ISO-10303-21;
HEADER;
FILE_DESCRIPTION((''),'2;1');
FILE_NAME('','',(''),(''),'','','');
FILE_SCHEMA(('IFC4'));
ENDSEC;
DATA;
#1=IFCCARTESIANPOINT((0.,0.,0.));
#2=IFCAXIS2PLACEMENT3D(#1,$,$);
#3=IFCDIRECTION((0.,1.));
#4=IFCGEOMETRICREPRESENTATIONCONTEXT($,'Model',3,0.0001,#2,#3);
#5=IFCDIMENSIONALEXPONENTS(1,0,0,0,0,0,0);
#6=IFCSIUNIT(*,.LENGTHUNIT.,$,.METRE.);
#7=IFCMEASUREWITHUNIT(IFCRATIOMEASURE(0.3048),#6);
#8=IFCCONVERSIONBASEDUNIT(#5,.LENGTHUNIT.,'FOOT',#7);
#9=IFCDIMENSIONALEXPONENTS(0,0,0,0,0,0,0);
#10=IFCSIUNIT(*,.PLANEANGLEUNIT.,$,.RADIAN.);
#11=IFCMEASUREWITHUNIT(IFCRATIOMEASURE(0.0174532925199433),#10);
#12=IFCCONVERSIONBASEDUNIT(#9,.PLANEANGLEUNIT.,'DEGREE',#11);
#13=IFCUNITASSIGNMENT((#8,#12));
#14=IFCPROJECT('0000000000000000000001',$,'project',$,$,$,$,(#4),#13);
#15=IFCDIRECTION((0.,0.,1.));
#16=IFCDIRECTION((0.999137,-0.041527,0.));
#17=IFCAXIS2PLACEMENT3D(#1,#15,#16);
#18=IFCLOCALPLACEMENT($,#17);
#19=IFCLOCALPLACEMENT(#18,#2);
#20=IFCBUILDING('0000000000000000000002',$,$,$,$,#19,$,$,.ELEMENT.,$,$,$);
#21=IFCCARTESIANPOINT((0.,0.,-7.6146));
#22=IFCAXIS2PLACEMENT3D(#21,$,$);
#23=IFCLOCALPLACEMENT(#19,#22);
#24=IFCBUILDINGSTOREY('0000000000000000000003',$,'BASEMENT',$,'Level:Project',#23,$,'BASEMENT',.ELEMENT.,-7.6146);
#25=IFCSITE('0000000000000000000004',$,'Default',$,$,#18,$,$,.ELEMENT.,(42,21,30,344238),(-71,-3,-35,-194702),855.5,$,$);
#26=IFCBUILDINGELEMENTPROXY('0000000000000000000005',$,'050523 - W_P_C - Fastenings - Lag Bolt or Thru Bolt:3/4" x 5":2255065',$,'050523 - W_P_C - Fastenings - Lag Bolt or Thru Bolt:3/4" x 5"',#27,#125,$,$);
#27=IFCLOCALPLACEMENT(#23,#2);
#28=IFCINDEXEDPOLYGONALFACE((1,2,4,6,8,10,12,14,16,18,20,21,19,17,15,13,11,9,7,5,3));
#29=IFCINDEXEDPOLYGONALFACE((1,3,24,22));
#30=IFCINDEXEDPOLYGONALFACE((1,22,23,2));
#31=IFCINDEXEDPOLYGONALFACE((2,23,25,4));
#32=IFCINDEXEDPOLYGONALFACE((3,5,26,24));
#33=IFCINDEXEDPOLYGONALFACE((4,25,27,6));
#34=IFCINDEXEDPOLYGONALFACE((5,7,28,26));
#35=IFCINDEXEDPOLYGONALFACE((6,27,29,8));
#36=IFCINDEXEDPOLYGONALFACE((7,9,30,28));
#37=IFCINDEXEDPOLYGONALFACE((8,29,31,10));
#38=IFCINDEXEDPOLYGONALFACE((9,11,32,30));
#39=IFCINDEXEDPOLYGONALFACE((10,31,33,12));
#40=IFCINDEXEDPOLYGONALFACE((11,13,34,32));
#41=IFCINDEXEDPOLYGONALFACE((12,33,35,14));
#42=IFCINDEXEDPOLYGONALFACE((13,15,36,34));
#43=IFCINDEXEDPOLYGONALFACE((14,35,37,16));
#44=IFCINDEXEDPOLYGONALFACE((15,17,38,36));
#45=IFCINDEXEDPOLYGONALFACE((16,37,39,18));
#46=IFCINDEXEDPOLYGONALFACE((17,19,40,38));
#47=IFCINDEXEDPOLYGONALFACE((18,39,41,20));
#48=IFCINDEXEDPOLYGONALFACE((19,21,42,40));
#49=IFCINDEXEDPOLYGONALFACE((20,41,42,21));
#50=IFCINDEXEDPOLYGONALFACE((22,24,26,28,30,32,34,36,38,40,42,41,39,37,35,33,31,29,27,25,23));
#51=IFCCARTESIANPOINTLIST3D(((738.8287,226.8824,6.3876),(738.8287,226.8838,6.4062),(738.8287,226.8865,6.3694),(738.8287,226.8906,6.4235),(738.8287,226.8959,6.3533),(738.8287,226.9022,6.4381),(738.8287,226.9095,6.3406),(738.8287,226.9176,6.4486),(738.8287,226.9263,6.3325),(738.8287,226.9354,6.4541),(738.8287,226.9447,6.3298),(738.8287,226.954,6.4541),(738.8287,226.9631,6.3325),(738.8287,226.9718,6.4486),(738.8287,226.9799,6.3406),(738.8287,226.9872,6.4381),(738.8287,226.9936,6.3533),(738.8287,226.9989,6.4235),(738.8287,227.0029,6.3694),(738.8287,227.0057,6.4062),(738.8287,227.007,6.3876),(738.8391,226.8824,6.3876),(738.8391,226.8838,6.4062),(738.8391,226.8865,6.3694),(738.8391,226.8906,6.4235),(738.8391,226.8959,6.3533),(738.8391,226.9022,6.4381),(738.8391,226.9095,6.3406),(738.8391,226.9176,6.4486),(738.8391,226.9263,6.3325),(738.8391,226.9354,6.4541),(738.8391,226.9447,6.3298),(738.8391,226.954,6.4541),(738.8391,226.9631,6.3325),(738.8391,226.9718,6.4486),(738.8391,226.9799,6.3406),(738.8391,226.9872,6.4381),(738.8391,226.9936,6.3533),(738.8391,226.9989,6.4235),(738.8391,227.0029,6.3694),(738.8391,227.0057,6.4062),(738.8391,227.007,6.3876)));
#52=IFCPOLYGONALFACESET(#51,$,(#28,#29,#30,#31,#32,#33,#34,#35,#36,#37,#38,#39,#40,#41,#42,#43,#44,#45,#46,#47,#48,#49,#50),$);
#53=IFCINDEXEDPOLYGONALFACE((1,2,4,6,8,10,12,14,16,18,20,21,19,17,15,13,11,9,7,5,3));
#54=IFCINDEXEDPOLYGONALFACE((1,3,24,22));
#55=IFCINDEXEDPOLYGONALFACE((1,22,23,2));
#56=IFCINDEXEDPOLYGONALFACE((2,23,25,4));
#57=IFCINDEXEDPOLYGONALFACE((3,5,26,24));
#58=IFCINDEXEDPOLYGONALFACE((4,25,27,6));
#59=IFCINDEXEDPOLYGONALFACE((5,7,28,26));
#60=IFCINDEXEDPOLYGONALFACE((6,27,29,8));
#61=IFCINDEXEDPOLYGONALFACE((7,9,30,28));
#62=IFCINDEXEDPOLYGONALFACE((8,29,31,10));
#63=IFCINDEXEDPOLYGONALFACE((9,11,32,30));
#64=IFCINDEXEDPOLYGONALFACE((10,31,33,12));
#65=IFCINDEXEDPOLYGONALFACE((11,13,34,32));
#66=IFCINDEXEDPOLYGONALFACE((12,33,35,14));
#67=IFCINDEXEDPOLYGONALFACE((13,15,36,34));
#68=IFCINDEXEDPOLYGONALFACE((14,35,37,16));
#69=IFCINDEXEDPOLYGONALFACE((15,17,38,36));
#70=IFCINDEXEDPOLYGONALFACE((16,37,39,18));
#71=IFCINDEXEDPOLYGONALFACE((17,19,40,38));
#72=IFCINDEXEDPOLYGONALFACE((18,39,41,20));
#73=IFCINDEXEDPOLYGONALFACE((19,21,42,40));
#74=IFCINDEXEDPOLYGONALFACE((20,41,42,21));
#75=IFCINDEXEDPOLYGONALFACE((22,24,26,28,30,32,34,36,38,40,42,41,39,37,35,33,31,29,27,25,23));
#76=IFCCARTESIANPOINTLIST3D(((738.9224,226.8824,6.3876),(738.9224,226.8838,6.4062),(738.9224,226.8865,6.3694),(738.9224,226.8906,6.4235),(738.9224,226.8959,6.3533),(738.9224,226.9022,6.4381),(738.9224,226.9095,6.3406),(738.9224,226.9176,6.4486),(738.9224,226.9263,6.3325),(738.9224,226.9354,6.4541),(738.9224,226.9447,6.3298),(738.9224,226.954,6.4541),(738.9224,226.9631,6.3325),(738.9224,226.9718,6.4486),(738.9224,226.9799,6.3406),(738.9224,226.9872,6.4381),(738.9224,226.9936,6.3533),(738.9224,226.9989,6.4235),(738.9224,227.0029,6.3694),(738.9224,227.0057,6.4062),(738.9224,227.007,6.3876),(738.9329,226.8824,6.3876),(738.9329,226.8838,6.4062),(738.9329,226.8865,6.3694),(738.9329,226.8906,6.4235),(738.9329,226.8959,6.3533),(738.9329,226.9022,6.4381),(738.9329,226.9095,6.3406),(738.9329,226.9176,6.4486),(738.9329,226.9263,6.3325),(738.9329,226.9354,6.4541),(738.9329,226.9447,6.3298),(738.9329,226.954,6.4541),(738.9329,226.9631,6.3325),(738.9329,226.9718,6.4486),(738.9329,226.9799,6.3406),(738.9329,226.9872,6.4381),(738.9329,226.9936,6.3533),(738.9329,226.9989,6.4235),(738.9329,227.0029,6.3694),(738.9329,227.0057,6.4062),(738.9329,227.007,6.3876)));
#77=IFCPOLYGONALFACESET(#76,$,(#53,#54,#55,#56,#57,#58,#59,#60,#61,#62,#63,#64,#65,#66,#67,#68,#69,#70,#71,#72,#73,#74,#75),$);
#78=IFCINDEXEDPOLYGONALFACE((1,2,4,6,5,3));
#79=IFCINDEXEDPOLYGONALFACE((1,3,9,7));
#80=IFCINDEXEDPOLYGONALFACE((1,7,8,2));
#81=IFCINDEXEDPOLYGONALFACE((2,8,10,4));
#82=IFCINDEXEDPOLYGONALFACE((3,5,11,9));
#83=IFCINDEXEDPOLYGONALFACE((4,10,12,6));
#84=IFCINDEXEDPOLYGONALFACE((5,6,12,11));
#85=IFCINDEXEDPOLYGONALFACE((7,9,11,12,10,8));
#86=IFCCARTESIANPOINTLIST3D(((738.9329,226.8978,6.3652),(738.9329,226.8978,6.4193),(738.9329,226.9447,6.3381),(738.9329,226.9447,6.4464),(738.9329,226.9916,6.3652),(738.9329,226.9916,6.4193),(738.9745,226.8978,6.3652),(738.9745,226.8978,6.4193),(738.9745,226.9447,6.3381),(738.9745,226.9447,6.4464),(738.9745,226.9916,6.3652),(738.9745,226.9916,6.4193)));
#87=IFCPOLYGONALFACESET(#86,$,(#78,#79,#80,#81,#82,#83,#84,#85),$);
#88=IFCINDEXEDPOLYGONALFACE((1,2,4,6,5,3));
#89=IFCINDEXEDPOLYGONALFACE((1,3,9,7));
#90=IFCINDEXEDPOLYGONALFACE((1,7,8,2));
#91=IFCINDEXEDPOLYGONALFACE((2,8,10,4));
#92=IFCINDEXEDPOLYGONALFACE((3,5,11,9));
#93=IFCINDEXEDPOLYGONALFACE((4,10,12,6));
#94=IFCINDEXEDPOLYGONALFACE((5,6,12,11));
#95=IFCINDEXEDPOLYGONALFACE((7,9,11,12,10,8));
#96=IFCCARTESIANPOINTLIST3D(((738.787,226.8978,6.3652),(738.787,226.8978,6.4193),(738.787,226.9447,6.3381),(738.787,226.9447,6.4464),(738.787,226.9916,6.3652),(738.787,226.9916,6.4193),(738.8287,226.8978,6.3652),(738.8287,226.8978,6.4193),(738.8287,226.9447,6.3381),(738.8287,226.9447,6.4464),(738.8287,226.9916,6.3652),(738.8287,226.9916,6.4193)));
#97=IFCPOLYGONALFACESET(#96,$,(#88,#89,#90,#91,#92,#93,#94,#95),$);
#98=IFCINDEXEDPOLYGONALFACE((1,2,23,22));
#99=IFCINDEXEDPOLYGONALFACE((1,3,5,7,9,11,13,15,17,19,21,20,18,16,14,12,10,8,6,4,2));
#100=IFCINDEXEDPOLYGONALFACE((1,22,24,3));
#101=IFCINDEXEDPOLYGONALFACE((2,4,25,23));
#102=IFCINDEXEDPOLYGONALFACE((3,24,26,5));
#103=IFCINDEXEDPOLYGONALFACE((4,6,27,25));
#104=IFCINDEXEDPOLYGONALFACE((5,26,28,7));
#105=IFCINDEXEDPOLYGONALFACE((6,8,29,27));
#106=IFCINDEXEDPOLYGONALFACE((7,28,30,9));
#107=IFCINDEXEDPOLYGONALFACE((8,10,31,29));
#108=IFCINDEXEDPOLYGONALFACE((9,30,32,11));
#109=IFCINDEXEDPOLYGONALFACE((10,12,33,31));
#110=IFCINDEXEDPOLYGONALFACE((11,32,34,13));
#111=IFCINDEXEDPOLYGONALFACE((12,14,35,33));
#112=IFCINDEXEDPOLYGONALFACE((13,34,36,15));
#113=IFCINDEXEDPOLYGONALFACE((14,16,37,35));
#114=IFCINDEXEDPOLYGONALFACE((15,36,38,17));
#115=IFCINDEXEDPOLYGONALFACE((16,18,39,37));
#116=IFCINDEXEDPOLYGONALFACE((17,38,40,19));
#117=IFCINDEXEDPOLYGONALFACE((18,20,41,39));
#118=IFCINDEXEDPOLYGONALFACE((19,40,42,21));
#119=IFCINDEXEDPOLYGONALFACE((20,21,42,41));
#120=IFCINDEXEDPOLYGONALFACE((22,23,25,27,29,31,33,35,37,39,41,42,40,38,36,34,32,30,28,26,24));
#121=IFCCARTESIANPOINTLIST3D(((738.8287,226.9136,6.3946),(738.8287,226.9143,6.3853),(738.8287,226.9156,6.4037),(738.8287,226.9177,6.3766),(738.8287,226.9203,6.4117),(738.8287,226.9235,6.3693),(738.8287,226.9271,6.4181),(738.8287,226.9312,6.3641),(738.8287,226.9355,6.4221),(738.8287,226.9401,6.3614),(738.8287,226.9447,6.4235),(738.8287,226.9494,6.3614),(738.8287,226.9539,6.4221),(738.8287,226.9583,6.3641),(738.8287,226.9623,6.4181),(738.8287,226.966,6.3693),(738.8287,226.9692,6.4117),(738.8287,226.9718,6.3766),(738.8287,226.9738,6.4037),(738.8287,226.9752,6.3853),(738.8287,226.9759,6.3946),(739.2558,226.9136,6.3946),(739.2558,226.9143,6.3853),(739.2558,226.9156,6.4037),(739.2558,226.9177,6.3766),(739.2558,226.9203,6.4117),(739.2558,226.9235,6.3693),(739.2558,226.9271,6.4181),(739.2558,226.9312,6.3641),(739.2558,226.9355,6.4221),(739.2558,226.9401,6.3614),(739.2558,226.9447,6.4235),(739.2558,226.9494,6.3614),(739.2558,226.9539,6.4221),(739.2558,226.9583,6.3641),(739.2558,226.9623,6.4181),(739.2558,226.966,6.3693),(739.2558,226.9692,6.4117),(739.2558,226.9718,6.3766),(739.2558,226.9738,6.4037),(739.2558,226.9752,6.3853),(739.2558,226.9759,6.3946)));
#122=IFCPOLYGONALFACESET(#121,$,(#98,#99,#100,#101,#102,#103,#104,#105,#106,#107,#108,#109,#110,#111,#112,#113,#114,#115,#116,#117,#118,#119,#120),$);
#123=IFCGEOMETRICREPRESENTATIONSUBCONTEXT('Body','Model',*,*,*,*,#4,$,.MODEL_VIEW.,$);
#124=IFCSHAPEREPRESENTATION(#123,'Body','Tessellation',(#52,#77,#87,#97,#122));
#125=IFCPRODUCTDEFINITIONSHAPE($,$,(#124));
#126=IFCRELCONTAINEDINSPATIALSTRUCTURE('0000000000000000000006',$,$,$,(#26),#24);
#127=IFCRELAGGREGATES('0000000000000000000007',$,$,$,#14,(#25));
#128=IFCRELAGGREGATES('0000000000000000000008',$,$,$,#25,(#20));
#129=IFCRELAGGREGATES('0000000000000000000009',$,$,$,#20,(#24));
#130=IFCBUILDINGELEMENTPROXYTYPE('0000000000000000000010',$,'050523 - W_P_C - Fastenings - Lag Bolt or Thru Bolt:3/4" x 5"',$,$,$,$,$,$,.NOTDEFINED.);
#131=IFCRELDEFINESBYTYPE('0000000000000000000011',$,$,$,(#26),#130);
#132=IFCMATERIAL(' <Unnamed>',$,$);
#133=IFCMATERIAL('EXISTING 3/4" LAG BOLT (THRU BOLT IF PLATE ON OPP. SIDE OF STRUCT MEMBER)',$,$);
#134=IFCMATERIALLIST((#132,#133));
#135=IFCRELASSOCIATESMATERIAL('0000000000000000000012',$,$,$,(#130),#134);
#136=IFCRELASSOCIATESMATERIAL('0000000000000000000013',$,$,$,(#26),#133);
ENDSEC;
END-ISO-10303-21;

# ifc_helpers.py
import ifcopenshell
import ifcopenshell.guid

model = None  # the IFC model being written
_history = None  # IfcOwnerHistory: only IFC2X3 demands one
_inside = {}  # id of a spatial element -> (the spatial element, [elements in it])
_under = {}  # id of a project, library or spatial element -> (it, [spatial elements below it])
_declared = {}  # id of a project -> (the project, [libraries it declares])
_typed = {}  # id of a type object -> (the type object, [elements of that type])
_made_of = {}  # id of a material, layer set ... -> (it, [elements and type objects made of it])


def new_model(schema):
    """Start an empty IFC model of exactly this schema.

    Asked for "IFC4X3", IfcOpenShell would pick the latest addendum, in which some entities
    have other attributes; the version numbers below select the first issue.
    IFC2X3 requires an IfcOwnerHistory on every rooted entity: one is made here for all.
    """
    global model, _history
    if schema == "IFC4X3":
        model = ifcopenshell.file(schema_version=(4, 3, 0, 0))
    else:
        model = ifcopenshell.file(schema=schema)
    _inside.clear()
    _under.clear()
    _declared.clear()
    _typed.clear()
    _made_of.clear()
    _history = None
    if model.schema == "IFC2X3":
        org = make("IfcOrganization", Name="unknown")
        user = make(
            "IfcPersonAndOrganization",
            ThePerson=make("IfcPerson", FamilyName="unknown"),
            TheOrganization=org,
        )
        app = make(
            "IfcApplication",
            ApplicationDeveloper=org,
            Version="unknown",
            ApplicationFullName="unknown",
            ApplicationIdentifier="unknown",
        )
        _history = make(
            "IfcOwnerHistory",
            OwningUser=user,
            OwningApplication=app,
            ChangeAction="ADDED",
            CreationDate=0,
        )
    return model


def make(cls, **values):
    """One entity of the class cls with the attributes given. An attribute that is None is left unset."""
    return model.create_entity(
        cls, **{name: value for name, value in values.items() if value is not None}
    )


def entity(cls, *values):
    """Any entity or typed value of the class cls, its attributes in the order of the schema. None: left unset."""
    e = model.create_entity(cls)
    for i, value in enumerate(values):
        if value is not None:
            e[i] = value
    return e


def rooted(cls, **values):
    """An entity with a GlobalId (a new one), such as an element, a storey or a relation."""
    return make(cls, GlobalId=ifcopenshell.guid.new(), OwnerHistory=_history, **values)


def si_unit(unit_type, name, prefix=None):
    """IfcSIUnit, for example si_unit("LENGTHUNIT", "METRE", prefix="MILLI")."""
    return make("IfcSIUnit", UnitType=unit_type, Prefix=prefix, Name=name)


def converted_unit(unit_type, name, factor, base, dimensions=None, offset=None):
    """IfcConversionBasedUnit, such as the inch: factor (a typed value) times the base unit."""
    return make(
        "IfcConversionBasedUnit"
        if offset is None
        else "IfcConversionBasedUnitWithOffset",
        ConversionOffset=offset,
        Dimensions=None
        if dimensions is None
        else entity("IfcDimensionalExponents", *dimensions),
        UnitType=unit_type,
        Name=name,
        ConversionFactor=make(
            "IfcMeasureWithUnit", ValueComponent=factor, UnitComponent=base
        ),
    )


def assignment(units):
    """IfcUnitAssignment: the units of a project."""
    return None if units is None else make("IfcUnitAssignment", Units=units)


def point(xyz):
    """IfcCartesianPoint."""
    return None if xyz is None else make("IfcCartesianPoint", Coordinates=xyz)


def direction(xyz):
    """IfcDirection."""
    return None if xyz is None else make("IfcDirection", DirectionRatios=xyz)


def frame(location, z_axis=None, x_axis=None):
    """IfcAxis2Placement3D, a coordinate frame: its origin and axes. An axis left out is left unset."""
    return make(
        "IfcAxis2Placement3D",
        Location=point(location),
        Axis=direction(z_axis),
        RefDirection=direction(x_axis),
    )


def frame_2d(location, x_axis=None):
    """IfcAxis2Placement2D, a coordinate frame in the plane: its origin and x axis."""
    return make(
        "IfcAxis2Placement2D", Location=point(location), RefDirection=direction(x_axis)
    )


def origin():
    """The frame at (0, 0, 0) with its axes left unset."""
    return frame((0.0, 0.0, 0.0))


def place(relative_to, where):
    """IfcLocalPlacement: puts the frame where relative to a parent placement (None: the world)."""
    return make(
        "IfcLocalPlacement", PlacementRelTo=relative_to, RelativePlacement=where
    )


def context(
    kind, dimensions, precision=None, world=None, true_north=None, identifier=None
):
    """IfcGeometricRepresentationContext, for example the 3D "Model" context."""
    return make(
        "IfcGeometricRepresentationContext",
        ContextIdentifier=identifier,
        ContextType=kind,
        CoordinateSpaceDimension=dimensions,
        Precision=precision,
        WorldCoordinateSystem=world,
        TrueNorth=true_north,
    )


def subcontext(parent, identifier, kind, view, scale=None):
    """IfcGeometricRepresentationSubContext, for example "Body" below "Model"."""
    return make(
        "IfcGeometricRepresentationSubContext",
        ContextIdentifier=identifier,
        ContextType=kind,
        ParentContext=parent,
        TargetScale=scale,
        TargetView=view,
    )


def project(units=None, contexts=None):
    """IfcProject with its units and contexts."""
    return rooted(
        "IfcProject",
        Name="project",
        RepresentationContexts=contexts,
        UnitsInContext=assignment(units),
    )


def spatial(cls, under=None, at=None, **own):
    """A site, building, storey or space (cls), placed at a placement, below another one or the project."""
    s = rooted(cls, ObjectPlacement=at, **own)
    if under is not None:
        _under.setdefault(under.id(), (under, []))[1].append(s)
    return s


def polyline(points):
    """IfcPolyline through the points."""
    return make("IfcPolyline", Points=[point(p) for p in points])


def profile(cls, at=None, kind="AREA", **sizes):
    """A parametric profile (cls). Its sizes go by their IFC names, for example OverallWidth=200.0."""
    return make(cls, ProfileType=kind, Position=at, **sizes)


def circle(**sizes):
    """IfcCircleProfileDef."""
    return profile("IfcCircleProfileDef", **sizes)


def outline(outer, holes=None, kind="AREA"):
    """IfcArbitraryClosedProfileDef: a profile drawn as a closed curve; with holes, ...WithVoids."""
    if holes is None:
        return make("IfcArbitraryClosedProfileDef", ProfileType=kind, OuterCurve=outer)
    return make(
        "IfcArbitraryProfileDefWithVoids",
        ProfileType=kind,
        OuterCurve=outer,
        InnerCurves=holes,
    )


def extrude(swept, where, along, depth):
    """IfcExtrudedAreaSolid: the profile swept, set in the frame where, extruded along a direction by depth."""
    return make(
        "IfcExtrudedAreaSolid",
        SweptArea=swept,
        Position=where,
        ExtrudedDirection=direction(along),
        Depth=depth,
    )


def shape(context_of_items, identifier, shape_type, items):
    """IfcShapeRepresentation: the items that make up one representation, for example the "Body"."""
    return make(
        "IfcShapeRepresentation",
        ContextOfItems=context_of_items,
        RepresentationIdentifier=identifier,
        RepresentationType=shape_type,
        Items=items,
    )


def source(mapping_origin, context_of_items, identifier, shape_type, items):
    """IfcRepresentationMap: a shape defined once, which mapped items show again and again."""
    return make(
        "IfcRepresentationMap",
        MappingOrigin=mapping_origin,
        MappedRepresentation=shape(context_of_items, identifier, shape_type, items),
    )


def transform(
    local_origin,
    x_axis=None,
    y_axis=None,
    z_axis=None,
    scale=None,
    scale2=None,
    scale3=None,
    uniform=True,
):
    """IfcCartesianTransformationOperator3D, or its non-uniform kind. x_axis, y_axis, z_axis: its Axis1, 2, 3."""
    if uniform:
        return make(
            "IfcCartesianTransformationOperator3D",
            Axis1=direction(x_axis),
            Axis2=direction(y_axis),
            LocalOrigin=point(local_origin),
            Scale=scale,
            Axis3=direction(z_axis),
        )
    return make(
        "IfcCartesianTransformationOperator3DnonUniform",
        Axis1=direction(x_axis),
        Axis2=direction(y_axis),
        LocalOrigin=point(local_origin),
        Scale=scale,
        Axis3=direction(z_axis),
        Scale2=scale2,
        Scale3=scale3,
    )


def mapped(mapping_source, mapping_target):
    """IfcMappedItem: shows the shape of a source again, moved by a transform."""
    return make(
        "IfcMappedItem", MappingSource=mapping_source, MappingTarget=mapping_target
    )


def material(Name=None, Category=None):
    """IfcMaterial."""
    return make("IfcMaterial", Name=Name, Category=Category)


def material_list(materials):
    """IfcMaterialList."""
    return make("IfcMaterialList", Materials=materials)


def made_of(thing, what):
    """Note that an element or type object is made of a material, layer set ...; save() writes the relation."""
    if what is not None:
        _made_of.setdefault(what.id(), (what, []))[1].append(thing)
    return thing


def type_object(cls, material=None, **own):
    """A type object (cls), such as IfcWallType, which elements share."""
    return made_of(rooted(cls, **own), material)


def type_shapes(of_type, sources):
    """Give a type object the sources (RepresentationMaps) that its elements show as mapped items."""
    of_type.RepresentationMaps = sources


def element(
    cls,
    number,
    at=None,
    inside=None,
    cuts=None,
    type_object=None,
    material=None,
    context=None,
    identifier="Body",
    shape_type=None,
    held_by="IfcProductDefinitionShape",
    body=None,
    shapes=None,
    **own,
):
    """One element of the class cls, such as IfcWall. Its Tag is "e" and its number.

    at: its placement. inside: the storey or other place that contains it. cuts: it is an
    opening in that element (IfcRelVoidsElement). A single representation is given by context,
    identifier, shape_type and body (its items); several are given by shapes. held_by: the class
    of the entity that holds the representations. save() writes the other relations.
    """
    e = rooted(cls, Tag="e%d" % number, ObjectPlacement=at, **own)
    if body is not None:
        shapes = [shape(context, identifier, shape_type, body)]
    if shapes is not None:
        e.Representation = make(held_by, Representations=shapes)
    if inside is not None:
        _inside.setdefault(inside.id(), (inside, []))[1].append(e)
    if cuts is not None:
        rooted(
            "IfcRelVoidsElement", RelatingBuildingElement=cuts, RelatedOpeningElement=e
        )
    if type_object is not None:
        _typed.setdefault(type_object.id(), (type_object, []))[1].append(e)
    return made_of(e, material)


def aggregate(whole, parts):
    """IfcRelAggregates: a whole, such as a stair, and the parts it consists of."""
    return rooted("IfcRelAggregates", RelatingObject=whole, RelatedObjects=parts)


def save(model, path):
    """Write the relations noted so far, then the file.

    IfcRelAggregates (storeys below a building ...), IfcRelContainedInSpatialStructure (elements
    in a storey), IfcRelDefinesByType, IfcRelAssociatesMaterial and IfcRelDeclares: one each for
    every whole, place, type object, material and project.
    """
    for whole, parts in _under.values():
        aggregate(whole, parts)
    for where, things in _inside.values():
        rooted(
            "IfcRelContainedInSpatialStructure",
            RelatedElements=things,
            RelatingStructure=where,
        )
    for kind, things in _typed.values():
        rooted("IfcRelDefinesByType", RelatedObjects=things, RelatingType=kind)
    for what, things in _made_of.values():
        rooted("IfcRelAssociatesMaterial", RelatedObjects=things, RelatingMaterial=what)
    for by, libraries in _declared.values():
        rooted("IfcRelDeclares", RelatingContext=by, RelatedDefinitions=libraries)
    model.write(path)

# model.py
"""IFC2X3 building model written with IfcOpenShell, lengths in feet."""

from ifc_helpers import new_model, entity, si_unit, converted_unit, direction, frame, frame_2d, origin, place, context, subcontext, project, spatial, polyline, circle, outline, extrude, source, transform, mapped, material, material_list, type_object, type_shapes, element, save


model = new_model("IFC2X3")

# Units and contexts
model_context = context("Model", 3, precision=0.0001, world=origin(), true_north=direction((0.0, 1.0)))
body_context = subcontext(model_context, "Body", "Model", "MODEL_VIEW")
ifc_project = project(units=[converted_unit("LENGTHUNIT", "FOOT", entity("IfcRatioMeasure", 0.3048), si_unit("LENGTHUNIT", "METRE"), dimensions=[1, 0, 0, 0, 0, 0, 0]), converted_unit("PLANEANGLEUNIT", "DEGREE", entity("IfcRatioMeasure", 0.0174532925199433), si_unit("PLANEANGLEUNIT", "RADIAN"), dimensions=[0, 0, 0, 0, 0, 0, 0])], contexts=[model_context])

# Site, building, storey
site_placement = place(None, frame((0.0, 0.0, 0.0), z_axis=(0.0, 0.0, 1.0), x_axis=(0.999137, -0.041527, 0.0)))
site = spatial("IfcSite", under=ifc_project, at=site_placement, Name="Default", CompositionType="ELEMENT", RefLatitude=(42, 21, 30, 344238), RefLongitude=(-71, -3, -35, -194702), RefElevation=855.5)
building_placement = place(site_placement, origin())
building = spatial("IfcBuilding", under=site, at=building_placement, CompositionType="ELEMENT")
storey_placement = place(building_placement, frame((0.0, 0.0, -7.6146)))
storey = spatial("IfcBuildingStorey", under=building, at=storey_placement, Name="BASEMENT", ObjectType="Level:Project", LongName="BASEMENT", CompositionType="ELEMENT", Elevation=-7.6146)

# Building element proxy
ifc_material_1 = material(Name="EXISTING 3/4\" LAG BOLT (THRU BOLT IF PLATE ON OPP. SIDE OF STRUCT MEMBER)")
ifc_material_2 = material(Name=" <Unnamed>")
ifc_material_list_1 = material_list([ifc_material_2, ifc_material_1])
building_element_proxy_type_1 = type_object("IfcBuildingElementProxyType", Name="050523 - W_P_C - Fastenings - Lag Bolt or Thru Bolt:3/4\" x 5\"", PredefinedType="NOTDEFINED", material=ifc_material_list_1)
shared_shape_1 = source(origin(), body_context, "Body", "SweptSolid", [
    extrude(circle(Radius=0.0625, at=frame_2d((0.0, 0.0), x_axis=(1.0, 0.0))), frame((0.0, 0.0, 0.0), z_axis=(0.0, 0.0, 1.0), x_axis=(0.0, -1.0, 0.0)), (0.0, 0.0, 1.0), 0.0104),
    extrude(circle(Radius=0.0625, at=frame_2d((0.0, 0.0), x_axis=(1.0, 0.0))), frame((0.0, 0.0, -0.0938), z_axis=(0.0, 0.0, 1.0), x_axis=(0.0, -1.0, 0.0)), (0.0, 0.0, 1.0), 0.0104),
    extrude(outline(polyline([(-0.0271, -0.0469), (0.0271, -0.0469), (0.0541, 0.0), (0.0271, 0.0469), (-0.0271, 0.0469), (-0.0541, 0.0), (-0.0271, -0.0469)])), frame((0.0, 0.0, -0.1354), z_axis=(0.0, 0.0, 1.0), x_axis=(0.866025, -0.5, 0.0)), (0.0, 0.0, 1.0), 0.0417),
    extrude(outline(polyline([(-0.0271, -0.0469), (0.0271, -0.0469), (0.0541, 0.0), (0.0271, 0.0469), (-0.0271, 0.0469), (-0.0541, 0.0), (-0.0271, -0.0469)])), frame((0.0, 0.0, 0.0104), z_axis=(0.0, 0.0, 1.0), x_axis=(0.0, -1.0, 0.0)), (0.0, 0.0, 1.0), 0.0417),
    extrude(circle(Radius=0.0312, at=frame_2d((0.0, 0.0), x_axis=(1.0, 0.0))), frame((0.0, 0.0, -0.4167), z_axis=(0.0, 0.0, 1.0), x_axis=(0.0, 1.0, 0.0)), (0.0, 0.0, 1.0), 0.4271),
])
type_shapes(building_element_proxy_type_1, [shared_shape_1])
for number, where, z_axis, x_axis, name in (
    (1, (738.8391, 226.9447, 6.3923), (-1.0, 0.0, 0.0), (0.0, -1.0, 0.0), "050523 - W_P_C - Fastenings - Lag Bolt or Thru Bolt:3/4\" x 5\":2255065"),
):
    element("IfcBuildingElementProxy", number, at=place(storey_placement, frame(where, z_axis=z_axis, x_axis=x_axis)), inside=storey, type_object=building_element_proxy_type_1, material=ifc_material_1, Name=name, ObjectType="050523 - W_P_C - Fastenings - Lag Bolt or Thru Bolt:3/4\" x 5\"", context=body_context, shape_type="MappedRepresentation", body=[
        mapped(shared_shape_1, transform((0.0, 0.0, 0.0), scale=1.0)),
    ])

save(model, "model.ifc")
